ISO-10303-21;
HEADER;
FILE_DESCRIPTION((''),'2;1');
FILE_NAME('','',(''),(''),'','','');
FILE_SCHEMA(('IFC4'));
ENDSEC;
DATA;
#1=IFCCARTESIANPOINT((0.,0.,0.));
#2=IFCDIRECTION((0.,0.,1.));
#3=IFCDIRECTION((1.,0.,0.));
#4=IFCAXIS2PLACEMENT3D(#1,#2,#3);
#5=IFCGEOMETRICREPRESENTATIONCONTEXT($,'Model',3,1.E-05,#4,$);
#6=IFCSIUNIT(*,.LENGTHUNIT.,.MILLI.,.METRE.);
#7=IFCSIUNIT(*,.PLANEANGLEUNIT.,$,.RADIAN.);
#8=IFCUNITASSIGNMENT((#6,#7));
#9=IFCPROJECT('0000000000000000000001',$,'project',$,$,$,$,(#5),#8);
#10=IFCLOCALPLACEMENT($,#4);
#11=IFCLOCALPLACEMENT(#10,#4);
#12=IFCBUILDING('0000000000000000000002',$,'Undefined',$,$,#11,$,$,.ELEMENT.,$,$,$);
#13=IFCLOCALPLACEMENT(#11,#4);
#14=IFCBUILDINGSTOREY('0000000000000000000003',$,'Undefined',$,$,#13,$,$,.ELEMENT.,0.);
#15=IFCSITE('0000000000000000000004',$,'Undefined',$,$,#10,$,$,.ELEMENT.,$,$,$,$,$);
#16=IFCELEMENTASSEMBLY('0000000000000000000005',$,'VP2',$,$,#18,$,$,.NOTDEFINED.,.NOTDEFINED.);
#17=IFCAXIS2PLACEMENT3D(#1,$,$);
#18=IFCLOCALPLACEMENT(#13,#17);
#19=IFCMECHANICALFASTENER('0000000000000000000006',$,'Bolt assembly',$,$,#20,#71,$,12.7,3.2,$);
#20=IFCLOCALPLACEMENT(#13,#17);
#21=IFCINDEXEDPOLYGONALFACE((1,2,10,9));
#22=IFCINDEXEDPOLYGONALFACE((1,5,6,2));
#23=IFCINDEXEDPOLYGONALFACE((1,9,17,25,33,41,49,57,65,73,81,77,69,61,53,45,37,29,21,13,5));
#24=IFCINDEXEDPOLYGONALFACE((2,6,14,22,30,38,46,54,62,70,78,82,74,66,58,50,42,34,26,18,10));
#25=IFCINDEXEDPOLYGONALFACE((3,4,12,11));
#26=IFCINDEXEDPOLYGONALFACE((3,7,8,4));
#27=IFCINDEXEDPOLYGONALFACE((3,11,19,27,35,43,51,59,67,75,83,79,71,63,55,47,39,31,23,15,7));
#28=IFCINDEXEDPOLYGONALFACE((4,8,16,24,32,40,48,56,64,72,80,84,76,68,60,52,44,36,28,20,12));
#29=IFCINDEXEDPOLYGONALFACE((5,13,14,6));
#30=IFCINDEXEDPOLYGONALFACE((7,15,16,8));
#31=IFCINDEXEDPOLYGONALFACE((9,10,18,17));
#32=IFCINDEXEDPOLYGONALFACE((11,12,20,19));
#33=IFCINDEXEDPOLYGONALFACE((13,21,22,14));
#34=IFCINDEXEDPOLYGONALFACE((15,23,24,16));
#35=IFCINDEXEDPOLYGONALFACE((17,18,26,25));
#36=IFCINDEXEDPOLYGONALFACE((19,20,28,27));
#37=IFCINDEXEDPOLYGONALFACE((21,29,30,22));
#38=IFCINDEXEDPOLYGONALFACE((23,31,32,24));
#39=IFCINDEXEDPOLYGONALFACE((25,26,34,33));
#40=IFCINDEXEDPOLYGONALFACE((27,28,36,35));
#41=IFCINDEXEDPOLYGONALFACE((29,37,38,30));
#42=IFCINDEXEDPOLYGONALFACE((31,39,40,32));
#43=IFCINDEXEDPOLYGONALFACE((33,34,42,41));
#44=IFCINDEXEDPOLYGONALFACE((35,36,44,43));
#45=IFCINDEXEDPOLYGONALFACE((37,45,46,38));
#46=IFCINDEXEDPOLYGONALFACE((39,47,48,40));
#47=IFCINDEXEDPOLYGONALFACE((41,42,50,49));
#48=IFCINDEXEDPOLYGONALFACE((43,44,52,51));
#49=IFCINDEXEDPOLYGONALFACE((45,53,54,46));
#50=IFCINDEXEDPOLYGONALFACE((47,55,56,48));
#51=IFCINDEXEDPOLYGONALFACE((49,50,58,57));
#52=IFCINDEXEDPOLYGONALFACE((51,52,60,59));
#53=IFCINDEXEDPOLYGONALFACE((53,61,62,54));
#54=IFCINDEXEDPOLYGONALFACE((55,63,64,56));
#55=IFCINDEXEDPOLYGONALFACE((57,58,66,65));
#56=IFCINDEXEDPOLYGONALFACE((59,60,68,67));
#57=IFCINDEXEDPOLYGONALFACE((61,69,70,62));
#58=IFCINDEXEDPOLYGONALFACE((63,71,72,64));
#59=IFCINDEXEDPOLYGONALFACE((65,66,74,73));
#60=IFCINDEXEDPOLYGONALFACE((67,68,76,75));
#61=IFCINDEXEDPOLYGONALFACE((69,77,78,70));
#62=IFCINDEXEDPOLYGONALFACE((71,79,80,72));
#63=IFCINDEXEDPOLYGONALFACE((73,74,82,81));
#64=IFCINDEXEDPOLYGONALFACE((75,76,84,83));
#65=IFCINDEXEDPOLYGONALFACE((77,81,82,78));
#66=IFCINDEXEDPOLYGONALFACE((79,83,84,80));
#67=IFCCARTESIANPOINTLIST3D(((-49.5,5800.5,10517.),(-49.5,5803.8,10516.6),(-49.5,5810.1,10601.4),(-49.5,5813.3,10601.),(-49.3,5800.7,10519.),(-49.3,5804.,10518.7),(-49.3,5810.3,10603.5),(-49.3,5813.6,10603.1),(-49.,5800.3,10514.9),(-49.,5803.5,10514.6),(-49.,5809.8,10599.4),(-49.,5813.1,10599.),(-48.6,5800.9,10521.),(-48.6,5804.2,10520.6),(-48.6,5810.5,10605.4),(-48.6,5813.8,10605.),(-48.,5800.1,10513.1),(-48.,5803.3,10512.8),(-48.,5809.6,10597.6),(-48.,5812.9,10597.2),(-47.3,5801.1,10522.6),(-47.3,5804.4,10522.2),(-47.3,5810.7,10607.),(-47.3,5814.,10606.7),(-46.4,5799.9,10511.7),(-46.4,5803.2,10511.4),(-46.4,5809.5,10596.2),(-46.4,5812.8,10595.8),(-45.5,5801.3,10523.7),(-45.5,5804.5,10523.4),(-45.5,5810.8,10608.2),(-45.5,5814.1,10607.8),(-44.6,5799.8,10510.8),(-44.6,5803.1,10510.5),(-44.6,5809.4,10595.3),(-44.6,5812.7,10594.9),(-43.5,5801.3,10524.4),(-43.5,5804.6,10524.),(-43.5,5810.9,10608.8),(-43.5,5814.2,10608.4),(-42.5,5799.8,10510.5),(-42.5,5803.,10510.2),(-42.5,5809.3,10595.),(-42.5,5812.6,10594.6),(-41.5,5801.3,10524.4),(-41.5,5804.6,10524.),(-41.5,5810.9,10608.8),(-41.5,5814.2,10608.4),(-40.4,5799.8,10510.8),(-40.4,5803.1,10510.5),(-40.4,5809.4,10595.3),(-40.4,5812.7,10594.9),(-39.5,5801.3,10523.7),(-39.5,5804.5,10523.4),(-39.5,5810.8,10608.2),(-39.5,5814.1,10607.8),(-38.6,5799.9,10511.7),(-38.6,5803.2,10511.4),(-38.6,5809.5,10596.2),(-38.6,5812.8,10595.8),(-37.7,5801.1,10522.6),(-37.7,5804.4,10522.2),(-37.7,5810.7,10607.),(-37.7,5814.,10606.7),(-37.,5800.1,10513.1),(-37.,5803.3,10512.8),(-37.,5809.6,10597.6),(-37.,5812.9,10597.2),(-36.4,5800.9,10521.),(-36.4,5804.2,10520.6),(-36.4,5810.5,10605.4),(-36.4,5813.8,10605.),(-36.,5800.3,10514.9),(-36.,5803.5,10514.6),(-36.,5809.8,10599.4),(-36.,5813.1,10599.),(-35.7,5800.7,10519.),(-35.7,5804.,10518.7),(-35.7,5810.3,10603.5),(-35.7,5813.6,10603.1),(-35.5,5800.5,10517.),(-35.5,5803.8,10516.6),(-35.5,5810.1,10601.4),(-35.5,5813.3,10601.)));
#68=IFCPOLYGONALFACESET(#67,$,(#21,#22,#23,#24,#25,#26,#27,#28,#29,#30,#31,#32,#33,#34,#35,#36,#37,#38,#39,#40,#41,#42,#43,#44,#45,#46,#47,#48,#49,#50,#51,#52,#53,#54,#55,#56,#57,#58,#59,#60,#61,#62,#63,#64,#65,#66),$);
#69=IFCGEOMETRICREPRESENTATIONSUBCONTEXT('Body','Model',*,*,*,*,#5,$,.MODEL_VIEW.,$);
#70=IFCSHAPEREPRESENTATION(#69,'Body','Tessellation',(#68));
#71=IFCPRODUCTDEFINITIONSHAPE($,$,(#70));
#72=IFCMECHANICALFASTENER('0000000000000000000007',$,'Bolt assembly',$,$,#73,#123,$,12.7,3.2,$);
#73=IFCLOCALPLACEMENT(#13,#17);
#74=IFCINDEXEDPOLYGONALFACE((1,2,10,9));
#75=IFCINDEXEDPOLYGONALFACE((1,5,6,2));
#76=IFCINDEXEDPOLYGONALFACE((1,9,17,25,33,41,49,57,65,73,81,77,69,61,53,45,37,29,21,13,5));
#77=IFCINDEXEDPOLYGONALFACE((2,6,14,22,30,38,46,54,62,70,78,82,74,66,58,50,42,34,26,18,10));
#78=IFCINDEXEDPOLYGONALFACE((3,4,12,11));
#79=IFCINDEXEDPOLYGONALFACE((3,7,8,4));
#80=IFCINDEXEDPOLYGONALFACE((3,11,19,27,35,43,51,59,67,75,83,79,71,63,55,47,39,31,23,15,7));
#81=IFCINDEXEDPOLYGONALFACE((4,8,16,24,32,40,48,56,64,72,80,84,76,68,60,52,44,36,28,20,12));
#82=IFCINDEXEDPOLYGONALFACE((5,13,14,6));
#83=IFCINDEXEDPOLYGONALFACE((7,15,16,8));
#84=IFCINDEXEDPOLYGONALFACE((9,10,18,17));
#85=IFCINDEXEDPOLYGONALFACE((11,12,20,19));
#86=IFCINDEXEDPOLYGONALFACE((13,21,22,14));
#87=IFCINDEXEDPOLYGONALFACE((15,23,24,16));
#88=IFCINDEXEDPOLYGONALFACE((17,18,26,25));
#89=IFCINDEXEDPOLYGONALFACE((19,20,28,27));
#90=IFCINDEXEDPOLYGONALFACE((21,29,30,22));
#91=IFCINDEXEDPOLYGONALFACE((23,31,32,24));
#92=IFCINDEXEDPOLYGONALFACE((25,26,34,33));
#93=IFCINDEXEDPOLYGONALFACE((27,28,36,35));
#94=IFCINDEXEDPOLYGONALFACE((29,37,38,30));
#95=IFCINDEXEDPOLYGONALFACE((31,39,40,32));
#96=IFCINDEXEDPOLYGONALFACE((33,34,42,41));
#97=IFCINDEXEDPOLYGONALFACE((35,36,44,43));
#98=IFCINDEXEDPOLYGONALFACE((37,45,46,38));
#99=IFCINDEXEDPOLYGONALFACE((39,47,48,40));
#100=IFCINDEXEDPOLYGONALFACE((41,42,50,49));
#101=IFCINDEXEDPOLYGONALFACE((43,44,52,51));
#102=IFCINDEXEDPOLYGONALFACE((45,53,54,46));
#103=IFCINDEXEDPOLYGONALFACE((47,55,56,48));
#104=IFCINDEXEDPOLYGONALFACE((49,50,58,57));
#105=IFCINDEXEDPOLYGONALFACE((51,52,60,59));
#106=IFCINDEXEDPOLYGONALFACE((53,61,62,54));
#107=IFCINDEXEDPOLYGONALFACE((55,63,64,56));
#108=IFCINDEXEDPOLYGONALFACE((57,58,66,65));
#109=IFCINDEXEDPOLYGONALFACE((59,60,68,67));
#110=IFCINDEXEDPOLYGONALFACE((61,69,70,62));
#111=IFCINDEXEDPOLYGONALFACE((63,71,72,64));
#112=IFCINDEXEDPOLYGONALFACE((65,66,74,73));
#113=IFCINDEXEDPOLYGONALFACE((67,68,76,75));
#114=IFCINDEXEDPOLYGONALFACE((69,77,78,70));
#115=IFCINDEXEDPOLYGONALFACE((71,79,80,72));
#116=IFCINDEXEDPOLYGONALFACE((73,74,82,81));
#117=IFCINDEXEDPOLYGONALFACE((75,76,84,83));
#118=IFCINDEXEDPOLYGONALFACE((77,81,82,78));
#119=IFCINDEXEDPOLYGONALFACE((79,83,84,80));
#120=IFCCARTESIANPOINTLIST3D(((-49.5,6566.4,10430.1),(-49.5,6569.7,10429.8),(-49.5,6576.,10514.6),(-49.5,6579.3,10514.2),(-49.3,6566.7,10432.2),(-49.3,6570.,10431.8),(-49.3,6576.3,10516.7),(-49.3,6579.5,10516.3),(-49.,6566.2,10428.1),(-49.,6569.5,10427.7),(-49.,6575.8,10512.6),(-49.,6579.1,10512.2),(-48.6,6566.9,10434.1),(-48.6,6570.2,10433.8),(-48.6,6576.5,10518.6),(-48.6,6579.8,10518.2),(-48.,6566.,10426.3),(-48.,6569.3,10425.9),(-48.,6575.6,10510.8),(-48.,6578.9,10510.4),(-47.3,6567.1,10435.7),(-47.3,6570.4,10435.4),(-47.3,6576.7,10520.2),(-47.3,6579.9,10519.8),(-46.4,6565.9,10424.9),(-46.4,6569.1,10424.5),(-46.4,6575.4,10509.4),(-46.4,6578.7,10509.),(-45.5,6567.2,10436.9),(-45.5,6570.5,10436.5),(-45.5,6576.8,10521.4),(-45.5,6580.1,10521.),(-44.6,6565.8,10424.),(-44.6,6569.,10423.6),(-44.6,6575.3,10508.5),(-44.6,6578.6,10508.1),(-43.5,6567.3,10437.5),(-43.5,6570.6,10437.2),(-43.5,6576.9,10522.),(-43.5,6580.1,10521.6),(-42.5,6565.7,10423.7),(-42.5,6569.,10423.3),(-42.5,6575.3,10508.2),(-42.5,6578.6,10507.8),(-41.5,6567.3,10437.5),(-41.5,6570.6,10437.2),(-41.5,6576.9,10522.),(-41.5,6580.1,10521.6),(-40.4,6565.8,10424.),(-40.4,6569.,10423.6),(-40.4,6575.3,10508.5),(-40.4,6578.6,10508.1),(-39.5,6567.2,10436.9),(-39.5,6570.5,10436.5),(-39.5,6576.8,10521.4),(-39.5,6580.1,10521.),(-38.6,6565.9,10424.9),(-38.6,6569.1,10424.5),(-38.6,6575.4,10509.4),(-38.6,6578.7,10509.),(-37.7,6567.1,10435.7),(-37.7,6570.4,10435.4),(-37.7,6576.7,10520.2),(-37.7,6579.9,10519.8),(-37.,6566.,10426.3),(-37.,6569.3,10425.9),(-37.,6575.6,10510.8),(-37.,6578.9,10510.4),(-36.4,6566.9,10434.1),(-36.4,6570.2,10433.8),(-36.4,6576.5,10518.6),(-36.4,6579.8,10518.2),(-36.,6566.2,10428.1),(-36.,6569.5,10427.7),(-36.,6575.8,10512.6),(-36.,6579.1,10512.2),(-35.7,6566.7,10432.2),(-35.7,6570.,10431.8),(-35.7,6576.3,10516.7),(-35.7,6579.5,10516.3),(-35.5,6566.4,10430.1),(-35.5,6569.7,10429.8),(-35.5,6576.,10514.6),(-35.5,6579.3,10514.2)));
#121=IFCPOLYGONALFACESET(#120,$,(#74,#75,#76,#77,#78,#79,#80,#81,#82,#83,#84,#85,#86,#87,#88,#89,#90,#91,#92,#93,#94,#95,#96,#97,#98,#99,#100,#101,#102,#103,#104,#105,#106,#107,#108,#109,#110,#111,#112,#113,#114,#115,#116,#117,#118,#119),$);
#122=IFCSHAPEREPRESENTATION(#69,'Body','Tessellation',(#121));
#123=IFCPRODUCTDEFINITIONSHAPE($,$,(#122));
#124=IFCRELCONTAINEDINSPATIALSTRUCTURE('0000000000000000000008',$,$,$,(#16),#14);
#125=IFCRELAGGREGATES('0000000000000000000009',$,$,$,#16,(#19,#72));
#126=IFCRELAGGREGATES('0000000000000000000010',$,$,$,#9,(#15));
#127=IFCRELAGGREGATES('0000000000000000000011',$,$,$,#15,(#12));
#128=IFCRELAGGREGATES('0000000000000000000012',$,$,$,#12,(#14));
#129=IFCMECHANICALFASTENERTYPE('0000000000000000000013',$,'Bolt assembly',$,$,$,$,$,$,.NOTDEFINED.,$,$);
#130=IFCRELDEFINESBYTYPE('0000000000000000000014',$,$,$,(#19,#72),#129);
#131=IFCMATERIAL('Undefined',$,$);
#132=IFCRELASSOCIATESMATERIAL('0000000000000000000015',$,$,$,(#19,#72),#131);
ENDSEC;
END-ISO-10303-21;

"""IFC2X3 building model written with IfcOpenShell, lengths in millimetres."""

from ifc_helpers import new_model, si_unit, frame, origin_with_axes, origin_2d_with_axis, place, context, subcontext, project, spatial, circle, extrude, source, transform, mapped, material, type_object, element, aggregate, save


model = new_model("IFC2X3")

# Units and contexts
model_context = context("Model", 3, precision=1e-05, world=origin_with_axes())
body_context = subcontext(model_context, "Body", "Model", "MODEL_VIEW")
ifc_project = project(units=[si_unit("LENGTHUNIT", "METRE", prefix="MILLI"), si_unit("PLANEANGLEUNIT", "RADIAN")], contexts=[model_context])

# Site, building, storey
site_placement = place(None, origin_with_axes())
site = spatial("IfcSite", under=ifc_project, at=site_placement, Name="Undefined", CompositionType="ELEMENT")
building_placement = place(site_placement, origin_with_axes())
building = spatial("IfcBuilding", under=site, at=building_placement, Name="Undefined", CompositionType="ELEMENT")
storey_placement = place(building_placement, origin_with_axes())
storey = spatial("IfcBuildingStorey", under=building, at=storey_placement, Name="Undefined", CompositionType="ELEMENT", Elevation=0.0)

# Element assembly
assembly_1_placement = place(storey_placement, origin_with_axes())
assembly_1 = element("IfcElementAssembly", 1, at=assembly_1_placement, inside=storey, Name="VP2", AssemblyPlace="NOTDEFINED", PredefinedType="NOTDEFINED")

# Mechanical fasteners
ifc_material_1 = material(Name="Undefined")
mechanical_fastener_type = type_object("IfcMechanicalFastenerType", Name="Bolt assembly")
shared_shape_1 = source(origin_with_axes(), body_context, "Body", "SweptSolid", [
    extrude(circle(Radius=7.0, at=origin_2d_with_axis()), frame((0.0, -3.2, 0.0), z_axis=(0.0, 1.0, 0.0), x_axis=(1.0, 0.0, 0.0)), (0.0, 0.0, 1.0), 3.3),
])
mechanical_fastener_1_placement = place(assembly_1_placement, frame((-42.5, 5810.2, 10601.9), z_axis=(-1.0, 0.0, 0.0), x_axis=(0.0, -0.112644, -0.993635)))
mechanical_fastener_1 = element("IfcMechanicalFastener", 2, at=mechanical_fastener_1_placement, type_object=mechanical_fastener_type, material=ifc_material_1, Name="Bolt assembly", NominalDiameter=12.7, NominalLength=3.2, context=body_context, shape_type="MappedRepresentation", body=[
    mapped(shared_shape_1, transform((0.0, 0.0, 0.0))),
    mapped(shared_shape_1, transform((85.0, 0.0, 0.0))),
])
mechanical_fastener_2_placement = place(assembly_1_placement, frame((-42.5, 6579.3, 10514.7), z_axis=(1.0, 0.0, 0.0), x_axis=(0.0, -0.112644, -0.993635)))
mechanical_fastener_2 = element("IfcMechanicalFastener", 3, at=mechanical_fastener_2_placement, type_object=mechanical_fastener_type, material=ifc_material_1, Name="Bolt assembly", NominalDiameter=12.7, NominalLength=3.2, context=body_context, shape_type="MappedRepresentation", body=[
    mapped(shared_shape_1, transform((0.0, 0.0, 0.0))),
    mapped(shared_shape_1, transform((85.0, 0.0, 0.0))),
])

aggregate(assembly_1, [mechanical_fastener_1, mechanical_fastener_2])

save(model, "model.ifc")
